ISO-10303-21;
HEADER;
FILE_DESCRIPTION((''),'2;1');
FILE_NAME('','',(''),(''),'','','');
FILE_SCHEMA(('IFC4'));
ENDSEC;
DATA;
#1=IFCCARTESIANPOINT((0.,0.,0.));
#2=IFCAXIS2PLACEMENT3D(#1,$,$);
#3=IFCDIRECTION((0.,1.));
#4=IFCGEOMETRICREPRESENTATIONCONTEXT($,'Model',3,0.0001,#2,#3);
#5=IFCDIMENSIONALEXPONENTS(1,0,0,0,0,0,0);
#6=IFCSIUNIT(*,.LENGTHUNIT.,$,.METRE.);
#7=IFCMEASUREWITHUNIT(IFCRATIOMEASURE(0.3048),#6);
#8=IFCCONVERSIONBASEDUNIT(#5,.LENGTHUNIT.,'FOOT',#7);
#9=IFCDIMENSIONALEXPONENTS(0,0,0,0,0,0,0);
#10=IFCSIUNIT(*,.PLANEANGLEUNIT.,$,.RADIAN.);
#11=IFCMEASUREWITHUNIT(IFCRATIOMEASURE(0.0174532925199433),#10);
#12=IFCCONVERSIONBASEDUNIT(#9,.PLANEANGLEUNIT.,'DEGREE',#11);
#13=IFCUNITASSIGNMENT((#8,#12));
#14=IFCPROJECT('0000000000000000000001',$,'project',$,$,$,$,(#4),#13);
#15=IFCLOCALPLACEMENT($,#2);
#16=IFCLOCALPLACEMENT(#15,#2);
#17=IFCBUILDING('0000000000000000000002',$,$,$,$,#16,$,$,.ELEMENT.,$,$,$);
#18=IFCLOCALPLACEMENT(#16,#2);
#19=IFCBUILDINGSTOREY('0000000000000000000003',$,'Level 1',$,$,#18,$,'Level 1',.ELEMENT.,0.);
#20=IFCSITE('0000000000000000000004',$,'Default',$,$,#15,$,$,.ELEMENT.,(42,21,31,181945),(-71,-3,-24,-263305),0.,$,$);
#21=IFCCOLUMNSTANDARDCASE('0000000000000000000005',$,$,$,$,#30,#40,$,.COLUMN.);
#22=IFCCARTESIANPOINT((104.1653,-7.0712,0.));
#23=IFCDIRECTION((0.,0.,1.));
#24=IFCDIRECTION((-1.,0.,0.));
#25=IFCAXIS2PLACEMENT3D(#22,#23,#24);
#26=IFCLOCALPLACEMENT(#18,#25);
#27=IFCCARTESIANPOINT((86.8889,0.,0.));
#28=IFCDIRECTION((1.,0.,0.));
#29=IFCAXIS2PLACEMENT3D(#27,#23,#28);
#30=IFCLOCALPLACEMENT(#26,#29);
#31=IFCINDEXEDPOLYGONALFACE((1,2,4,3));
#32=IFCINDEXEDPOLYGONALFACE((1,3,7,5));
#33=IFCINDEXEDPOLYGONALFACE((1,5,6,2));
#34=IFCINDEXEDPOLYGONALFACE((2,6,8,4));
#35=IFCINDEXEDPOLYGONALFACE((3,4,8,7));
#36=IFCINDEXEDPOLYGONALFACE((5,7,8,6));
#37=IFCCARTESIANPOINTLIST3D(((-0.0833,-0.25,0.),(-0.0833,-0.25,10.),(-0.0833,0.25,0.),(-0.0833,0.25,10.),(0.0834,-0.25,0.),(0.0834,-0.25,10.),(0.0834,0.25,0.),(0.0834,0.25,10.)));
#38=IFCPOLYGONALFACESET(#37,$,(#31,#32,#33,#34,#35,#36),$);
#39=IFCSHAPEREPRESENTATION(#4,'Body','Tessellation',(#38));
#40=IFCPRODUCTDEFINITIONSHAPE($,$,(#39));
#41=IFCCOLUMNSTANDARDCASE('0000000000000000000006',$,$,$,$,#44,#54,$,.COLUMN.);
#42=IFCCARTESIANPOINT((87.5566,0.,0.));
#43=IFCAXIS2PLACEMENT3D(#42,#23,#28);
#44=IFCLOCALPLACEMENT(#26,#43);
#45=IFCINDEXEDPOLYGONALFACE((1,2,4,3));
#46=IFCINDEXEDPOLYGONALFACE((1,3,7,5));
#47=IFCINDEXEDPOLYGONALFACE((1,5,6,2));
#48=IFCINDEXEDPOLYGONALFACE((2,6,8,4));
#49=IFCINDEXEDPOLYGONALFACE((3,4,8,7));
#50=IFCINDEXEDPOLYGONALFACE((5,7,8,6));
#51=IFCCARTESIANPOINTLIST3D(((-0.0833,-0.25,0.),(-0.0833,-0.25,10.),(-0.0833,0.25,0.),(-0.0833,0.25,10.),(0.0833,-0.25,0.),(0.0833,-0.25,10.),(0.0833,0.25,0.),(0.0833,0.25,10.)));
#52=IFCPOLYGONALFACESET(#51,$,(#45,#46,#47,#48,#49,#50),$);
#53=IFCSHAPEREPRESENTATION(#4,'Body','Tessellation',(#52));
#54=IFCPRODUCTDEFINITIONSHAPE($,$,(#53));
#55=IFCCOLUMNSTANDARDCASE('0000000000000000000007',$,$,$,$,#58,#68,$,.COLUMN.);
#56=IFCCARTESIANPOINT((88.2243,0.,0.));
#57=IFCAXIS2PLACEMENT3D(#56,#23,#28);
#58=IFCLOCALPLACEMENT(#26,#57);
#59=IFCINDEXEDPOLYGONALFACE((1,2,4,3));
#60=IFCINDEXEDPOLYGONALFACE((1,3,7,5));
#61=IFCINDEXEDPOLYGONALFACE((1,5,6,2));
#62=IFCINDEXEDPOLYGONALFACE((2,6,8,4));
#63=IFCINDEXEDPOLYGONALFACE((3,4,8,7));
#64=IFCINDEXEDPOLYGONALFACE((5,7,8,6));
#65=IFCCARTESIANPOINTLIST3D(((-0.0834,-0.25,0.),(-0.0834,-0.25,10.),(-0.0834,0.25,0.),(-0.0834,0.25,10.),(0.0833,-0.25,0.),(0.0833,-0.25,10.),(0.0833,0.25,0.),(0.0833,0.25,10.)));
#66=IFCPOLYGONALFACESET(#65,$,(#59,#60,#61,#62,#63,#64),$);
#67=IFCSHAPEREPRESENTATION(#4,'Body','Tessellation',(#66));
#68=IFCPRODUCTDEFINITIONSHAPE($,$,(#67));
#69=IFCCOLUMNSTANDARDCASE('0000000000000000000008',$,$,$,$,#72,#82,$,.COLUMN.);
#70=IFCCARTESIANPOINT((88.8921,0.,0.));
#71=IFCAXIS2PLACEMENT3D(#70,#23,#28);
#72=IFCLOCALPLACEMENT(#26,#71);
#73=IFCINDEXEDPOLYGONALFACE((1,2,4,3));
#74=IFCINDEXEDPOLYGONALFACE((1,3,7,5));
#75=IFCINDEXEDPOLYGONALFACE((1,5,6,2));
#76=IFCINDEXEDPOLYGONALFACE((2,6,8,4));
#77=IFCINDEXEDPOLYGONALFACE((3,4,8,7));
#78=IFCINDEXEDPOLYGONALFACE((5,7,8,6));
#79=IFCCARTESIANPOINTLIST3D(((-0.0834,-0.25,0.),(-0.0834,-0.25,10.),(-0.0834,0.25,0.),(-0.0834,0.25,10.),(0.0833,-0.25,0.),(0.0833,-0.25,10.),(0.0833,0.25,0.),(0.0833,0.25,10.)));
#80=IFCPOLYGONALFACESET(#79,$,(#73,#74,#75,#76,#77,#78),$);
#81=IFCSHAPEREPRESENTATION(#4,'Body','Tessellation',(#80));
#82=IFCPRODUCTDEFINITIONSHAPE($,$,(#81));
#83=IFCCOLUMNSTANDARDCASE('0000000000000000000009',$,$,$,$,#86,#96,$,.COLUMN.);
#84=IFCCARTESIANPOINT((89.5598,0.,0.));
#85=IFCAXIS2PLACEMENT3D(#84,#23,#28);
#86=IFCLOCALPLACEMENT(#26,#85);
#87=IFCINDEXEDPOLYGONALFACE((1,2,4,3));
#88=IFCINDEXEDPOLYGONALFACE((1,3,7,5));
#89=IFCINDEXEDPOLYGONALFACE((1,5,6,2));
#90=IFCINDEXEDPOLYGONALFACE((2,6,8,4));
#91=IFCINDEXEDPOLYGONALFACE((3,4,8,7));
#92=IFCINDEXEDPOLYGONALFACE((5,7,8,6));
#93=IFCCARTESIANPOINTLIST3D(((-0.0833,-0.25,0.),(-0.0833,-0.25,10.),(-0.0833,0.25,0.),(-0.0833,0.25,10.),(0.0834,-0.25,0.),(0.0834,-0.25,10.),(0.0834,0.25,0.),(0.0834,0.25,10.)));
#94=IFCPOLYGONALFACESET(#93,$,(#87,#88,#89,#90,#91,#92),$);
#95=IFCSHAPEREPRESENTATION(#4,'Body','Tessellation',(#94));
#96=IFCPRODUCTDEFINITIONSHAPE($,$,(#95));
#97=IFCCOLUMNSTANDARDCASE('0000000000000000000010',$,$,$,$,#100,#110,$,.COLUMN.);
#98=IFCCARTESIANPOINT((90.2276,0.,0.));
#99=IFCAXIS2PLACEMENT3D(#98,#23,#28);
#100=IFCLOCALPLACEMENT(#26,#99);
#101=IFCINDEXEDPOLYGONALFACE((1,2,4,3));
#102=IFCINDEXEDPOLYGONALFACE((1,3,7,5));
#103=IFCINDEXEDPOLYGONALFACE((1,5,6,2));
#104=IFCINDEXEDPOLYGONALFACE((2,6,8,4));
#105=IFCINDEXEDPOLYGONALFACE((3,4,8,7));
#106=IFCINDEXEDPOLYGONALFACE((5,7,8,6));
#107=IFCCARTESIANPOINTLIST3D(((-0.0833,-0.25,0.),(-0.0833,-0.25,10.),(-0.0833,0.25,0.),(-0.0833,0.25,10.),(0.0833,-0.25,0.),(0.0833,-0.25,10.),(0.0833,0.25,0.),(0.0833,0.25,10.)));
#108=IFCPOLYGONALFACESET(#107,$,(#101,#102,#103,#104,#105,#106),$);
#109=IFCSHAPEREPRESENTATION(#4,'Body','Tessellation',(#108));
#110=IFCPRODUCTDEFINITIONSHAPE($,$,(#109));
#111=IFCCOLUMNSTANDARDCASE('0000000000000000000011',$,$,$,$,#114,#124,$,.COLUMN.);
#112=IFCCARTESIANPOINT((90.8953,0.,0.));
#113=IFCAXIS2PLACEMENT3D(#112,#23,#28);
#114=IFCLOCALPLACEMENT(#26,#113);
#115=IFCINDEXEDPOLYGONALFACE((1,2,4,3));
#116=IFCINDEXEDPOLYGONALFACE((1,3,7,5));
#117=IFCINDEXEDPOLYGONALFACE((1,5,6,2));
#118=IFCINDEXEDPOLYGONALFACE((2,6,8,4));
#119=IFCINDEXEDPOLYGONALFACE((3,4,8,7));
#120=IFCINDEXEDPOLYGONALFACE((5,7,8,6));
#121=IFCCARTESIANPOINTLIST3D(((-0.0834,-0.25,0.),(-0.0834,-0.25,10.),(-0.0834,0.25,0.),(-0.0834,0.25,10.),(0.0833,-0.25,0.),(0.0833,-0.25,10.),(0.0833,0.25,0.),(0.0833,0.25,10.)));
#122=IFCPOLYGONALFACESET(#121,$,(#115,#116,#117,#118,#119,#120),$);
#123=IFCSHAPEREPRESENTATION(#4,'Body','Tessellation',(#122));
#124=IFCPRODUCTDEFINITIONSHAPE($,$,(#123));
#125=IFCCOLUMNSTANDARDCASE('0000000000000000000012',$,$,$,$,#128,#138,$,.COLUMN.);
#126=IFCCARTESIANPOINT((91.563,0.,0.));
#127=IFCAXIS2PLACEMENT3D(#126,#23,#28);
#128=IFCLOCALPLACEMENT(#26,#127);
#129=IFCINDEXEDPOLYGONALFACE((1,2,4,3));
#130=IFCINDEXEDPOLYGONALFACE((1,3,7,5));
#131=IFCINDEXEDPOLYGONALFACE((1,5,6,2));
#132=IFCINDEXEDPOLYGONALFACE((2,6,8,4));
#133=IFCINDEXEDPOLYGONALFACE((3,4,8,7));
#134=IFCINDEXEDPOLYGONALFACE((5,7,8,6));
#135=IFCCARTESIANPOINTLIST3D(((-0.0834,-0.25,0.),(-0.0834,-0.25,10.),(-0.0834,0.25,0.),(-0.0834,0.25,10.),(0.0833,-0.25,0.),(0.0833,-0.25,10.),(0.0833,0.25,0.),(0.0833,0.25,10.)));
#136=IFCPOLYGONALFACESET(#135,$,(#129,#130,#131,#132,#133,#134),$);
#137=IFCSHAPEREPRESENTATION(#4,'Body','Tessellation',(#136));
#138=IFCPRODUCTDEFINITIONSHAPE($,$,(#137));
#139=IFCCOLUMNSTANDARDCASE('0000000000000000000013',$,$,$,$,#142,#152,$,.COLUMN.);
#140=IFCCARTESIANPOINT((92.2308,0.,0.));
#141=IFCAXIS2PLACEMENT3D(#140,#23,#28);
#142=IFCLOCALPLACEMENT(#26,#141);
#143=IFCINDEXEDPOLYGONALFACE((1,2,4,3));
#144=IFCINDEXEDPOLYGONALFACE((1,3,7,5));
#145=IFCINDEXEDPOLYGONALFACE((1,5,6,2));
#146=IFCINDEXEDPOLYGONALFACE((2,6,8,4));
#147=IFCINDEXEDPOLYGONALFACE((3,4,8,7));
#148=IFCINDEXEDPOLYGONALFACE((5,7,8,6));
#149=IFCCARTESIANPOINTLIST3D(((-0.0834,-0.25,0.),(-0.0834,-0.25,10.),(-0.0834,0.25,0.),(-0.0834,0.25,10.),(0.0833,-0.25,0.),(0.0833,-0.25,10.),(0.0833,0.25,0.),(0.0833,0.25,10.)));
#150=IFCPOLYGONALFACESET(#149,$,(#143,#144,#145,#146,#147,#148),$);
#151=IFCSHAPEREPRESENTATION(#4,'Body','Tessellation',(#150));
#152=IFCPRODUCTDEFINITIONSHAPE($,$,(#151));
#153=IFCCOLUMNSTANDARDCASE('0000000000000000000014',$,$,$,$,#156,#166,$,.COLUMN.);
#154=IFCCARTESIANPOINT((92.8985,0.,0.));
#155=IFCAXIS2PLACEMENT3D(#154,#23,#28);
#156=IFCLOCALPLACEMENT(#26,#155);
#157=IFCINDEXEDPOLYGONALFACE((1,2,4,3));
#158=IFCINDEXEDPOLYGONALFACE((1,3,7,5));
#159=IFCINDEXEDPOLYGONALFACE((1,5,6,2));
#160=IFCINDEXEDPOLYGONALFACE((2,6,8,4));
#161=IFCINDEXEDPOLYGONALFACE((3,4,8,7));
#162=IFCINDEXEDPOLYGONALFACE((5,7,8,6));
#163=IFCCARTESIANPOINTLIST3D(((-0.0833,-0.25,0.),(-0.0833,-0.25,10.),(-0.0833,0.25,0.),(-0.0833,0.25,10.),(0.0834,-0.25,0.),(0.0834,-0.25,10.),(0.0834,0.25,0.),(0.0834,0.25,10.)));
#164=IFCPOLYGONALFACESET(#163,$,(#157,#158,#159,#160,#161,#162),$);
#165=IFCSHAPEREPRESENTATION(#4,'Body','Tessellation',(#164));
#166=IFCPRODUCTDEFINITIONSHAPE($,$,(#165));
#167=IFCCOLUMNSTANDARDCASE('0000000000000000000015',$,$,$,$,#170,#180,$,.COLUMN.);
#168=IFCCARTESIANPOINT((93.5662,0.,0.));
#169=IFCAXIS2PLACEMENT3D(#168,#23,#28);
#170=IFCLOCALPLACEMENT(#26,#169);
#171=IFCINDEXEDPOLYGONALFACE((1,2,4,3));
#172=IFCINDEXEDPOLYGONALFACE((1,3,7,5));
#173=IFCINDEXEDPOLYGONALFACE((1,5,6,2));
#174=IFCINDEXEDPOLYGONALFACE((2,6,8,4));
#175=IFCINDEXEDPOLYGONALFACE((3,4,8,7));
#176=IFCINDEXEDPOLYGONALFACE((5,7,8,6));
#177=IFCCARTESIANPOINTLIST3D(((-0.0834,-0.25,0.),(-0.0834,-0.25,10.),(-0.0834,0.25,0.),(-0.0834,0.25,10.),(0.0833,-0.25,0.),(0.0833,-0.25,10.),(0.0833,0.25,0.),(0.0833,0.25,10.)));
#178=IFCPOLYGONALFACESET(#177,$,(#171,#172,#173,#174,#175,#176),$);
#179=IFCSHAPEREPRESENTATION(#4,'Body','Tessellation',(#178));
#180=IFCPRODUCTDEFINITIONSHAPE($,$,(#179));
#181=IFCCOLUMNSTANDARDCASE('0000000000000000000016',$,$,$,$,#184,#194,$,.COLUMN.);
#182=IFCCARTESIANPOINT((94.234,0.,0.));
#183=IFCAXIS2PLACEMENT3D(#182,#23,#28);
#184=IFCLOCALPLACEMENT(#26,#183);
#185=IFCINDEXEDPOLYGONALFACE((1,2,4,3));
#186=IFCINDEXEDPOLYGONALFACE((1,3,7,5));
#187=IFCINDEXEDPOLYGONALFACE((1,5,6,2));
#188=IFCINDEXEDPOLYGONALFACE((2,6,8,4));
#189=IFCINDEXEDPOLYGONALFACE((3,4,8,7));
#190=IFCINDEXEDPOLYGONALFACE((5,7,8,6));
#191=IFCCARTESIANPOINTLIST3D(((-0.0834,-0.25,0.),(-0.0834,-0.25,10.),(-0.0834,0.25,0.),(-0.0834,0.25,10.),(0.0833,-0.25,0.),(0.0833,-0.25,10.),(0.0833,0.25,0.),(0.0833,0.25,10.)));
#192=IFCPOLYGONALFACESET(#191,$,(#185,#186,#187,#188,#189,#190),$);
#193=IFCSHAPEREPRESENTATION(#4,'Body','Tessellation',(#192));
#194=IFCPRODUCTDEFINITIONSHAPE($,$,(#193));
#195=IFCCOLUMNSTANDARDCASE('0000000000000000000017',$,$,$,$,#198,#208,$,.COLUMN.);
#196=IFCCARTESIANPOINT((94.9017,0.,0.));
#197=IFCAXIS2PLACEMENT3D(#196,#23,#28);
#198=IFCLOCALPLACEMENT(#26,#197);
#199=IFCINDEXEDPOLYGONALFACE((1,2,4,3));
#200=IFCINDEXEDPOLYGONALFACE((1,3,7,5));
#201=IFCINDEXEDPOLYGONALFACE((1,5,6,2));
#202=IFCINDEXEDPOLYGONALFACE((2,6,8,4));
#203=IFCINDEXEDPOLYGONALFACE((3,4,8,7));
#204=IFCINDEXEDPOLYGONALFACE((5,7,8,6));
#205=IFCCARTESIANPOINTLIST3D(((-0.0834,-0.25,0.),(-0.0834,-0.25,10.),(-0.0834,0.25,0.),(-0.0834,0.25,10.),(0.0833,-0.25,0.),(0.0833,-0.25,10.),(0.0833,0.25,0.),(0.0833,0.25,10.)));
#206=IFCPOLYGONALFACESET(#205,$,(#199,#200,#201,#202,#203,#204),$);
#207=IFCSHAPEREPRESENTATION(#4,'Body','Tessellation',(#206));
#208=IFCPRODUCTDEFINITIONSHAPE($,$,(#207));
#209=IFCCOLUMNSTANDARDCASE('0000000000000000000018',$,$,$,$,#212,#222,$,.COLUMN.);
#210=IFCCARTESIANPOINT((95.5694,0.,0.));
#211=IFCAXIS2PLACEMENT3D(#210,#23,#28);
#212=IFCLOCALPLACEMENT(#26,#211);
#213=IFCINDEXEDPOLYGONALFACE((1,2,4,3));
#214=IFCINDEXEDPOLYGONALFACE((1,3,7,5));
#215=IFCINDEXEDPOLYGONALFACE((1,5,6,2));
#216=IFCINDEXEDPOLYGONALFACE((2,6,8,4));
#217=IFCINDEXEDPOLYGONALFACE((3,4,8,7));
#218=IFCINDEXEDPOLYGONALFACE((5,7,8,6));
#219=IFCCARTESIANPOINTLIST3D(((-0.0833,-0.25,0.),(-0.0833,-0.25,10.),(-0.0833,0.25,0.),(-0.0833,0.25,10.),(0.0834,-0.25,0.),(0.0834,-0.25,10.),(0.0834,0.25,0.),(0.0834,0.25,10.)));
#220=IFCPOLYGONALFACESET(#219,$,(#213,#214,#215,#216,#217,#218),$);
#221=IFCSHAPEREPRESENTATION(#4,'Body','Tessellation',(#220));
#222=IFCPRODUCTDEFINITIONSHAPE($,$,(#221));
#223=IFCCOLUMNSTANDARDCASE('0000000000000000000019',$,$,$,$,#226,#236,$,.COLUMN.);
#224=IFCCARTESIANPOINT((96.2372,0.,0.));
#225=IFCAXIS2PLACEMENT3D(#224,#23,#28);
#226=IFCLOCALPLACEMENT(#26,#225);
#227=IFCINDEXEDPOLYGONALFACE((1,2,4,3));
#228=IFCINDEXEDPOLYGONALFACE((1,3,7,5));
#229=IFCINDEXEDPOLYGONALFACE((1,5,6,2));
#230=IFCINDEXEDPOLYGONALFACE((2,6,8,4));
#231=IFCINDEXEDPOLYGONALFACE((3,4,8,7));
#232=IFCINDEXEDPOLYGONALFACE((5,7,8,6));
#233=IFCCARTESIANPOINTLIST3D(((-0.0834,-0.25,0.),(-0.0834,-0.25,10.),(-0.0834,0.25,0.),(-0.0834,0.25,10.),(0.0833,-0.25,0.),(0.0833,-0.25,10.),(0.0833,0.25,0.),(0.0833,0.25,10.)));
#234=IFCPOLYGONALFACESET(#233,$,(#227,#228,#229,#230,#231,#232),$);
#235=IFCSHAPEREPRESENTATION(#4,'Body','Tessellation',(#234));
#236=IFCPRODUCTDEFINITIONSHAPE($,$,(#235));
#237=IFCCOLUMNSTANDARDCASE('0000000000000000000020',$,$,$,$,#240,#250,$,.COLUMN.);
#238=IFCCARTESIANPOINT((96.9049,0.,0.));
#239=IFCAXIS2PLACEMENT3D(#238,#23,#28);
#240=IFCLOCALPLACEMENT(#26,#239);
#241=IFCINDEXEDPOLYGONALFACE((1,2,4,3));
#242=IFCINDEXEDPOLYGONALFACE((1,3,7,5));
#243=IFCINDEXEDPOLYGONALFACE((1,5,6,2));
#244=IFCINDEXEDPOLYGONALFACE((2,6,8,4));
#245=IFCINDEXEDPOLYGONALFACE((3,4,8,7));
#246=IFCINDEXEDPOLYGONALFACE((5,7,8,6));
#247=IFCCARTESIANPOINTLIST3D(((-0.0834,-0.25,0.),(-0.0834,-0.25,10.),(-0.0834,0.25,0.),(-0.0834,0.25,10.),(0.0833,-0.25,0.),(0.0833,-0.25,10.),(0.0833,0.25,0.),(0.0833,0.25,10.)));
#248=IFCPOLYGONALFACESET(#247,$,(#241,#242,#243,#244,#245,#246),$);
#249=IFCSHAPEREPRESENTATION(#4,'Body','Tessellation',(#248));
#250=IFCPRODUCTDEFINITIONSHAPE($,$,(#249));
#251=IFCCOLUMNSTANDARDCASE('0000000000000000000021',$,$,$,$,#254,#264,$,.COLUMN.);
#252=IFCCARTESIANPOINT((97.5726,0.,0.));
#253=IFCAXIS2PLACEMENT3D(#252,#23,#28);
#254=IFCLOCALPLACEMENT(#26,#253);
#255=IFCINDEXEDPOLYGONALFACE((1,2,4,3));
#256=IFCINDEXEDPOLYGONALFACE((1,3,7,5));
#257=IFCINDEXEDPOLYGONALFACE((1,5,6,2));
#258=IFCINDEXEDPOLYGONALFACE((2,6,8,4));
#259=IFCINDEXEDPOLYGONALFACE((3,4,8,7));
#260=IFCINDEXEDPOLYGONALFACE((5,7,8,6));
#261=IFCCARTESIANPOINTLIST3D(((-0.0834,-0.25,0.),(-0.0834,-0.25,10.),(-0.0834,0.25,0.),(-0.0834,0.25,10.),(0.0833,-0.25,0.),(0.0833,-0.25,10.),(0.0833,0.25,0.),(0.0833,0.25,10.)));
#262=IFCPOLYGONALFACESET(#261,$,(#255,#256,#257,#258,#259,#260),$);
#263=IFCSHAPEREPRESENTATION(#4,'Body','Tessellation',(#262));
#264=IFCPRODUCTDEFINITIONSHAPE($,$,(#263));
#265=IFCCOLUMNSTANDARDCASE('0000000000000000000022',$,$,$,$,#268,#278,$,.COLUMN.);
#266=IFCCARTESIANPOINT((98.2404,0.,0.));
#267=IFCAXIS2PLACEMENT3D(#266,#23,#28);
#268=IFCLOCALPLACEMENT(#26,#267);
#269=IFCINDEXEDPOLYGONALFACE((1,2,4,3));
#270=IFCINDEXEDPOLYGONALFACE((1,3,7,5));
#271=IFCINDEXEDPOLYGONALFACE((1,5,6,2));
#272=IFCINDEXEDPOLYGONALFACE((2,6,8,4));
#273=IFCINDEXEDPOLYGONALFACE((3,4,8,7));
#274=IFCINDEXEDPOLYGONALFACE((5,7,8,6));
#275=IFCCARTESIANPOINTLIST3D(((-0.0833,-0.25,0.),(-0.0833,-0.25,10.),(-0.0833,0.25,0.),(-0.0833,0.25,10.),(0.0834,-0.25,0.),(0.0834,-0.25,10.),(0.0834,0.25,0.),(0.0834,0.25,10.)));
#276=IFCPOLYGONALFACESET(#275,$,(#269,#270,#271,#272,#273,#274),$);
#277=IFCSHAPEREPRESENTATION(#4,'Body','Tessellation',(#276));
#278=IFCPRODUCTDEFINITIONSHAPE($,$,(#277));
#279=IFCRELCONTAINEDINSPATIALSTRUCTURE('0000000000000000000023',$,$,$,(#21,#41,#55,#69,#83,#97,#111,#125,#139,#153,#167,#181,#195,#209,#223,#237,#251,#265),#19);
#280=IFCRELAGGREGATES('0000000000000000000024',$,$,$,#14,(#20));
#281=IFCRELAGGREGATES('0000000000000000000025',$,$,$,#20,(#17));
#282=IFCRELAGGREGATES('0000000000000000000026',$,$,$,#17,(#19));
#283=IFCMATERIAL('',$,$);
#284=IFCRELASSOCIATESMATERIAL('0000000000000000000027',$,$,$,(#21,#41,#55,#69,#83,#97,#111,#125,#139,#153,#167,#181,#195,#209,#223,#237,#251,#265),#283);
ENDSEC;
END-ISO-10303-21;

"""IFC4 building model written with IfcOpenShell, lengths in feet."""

from ifc_helpers import new_model, entity, si_unit, converted_unit, direction, frame, origin, place, context, project, spatial, rectangle, extrude, material, element, save


model = new_model("IFC4")

# Units and contexts
model_context = context("Model", 3, precision=0.0001, world=origin(), true_north=direction((0.0, 1.0)))
ifc_project = project(units=[converted_unit("LENGTHUNIT", "FOOT", entity("IfcRatioMeasure", 0.3048), si_unit("LENGTHUNIT", "METRE"), dimensions=[1, 0, 0, 0, 0, 0, 0]), converted_unit("PLANEANGLEUNIT", "DEGREE", entity("IfcRatioMeasure", 0.0174532925199433), si_unit("PLANEANGLEUNIT", "RADIAN"), dimensions=[0, 0, 0, 0, 0, 0, 0])], contexts=[model_context])

# Site, building, storey
site_placement = place(None, origin())
site = spatial("IfcSite", under=ifc_project, at=site_placement, Name="Default", CompositionType="ELEMENT", RefLatitude=(42, 21, 31, 181945), RefLongitude=(-71, -3, -24, -263305), RefElevation=0.0)
building_placement = place(site_placement, origin())
building = spatial("IfcBuilding", under=site, at=building_placement, CompositionType="ELEMENT")
storey_placement = place(building_placement, origin())
storey = spatial("IfcBuildingStorey", under=building, at=storey_placement, Name="Level 1", LongName="Level 1", CompositionType="ELEMENT", Elevation=0.0)

# Columns
ifc_material = material(Name="")
placement = place(storey_placement, frame((104.1653, -7.0712, 0.0), z_axis=(0.0, 0.0, 1.0), x_axis=(-1.0, 0.0, 0.0)))
for number, where, z_axis, x_axis in (
    (1, (86.8889, 0.0, 0.0), (0.0, 0.0, 1.0), (1.0, 0.0, 0.0)),
    (2, (87.5566, 0.0, 0.0), (0.0, 0.0, 1.0), (1.0, 0.0, 0.0)),
    (3, (88.2243, 0.0, 0.0), (0.0, 0.0, 1.0), (1.0, 0.0, 0.0)),
    (4, (88.8921, 0.0, 0.0), (0.0, 0.0, 1.0), (1.0, 0.0, 0.0)),
    (5, (89.5598, 0.0, 0.0), (0.0, 0.0, 1.0), (1.0, 0.0, 0.0)),
    (6, (90.2276, 0.0, 0.0), (0.0, 0.0, 1.0), (1.0, 0.0, 0.0)),
    (7, (90.8953, 0.0, 0.0), (0.0, 0.0, 1.0), (1.0, 0.0, 0.0)),
    (8, (91.563, 0.0, 0.0), (0.0, 0.0, 1.0), (1.0, 0.0, 0.0)),
    (9, (92.2308, 0.0, 0.0), (0.0, 0.0, 1.0), (1.0, 0.0, 0.0)),
    (10, (92.8985, 0.0, 0.0), (0.0, 0.0, 1.0), (1.0, 0.0, 0.0)),
    (11, (93.5662, 0.0, 0.0), (0.0, 0.0, 1.0), (1.0, 0.0, 0.0)),
    (12, (94.234, 0.0, 0.0), (0.0, 0.0, 1.0), (1.0, 0.0, 0.0)),
    (13, (94.9017, 0.0, 0.0), (0.0, 0.0, 1.0), (1.0, 0.0, 0.0)),
    (14, (95.5694, 0.0, 0.0), (0.0, 0.0, 1.0), (1.0, 0.0, 0.0)),
    (15, (96.2372, 0.0, 0.0), (0.0, 0.0, 1.0), (1.0, 0.0, 0.0)),
    (16, (96.9049, 0.0, 0.0), (0.0, 0.0, 1.0), (1.0, 0.0, 0.0)),
    (17, (97.5726, 0.0, 0.0), (0.0, 0.0, 1.0), (1.0, 0.0, 0.0)),
    (18, (98.2404, 0.0, 0.0), (0.0, 0.0, 1.0), (1.0, 0.0, 0.0)),
):
    element("IfcColumnStandardCase", number, at=place(placement, frame(where, z_axis=z_axis, x_axis=x_axis)), inside=storey, material=ifc_material, PredefinedType="COLUMN", context=model_context, shape_type="SweptSolid", body=[
        extrude(rectangle(XDim=0.1667, YDim=0.5), origin(), (0.0, 0.0, 1.0), 10.0),
    ])

save(model, "model.ifc")
